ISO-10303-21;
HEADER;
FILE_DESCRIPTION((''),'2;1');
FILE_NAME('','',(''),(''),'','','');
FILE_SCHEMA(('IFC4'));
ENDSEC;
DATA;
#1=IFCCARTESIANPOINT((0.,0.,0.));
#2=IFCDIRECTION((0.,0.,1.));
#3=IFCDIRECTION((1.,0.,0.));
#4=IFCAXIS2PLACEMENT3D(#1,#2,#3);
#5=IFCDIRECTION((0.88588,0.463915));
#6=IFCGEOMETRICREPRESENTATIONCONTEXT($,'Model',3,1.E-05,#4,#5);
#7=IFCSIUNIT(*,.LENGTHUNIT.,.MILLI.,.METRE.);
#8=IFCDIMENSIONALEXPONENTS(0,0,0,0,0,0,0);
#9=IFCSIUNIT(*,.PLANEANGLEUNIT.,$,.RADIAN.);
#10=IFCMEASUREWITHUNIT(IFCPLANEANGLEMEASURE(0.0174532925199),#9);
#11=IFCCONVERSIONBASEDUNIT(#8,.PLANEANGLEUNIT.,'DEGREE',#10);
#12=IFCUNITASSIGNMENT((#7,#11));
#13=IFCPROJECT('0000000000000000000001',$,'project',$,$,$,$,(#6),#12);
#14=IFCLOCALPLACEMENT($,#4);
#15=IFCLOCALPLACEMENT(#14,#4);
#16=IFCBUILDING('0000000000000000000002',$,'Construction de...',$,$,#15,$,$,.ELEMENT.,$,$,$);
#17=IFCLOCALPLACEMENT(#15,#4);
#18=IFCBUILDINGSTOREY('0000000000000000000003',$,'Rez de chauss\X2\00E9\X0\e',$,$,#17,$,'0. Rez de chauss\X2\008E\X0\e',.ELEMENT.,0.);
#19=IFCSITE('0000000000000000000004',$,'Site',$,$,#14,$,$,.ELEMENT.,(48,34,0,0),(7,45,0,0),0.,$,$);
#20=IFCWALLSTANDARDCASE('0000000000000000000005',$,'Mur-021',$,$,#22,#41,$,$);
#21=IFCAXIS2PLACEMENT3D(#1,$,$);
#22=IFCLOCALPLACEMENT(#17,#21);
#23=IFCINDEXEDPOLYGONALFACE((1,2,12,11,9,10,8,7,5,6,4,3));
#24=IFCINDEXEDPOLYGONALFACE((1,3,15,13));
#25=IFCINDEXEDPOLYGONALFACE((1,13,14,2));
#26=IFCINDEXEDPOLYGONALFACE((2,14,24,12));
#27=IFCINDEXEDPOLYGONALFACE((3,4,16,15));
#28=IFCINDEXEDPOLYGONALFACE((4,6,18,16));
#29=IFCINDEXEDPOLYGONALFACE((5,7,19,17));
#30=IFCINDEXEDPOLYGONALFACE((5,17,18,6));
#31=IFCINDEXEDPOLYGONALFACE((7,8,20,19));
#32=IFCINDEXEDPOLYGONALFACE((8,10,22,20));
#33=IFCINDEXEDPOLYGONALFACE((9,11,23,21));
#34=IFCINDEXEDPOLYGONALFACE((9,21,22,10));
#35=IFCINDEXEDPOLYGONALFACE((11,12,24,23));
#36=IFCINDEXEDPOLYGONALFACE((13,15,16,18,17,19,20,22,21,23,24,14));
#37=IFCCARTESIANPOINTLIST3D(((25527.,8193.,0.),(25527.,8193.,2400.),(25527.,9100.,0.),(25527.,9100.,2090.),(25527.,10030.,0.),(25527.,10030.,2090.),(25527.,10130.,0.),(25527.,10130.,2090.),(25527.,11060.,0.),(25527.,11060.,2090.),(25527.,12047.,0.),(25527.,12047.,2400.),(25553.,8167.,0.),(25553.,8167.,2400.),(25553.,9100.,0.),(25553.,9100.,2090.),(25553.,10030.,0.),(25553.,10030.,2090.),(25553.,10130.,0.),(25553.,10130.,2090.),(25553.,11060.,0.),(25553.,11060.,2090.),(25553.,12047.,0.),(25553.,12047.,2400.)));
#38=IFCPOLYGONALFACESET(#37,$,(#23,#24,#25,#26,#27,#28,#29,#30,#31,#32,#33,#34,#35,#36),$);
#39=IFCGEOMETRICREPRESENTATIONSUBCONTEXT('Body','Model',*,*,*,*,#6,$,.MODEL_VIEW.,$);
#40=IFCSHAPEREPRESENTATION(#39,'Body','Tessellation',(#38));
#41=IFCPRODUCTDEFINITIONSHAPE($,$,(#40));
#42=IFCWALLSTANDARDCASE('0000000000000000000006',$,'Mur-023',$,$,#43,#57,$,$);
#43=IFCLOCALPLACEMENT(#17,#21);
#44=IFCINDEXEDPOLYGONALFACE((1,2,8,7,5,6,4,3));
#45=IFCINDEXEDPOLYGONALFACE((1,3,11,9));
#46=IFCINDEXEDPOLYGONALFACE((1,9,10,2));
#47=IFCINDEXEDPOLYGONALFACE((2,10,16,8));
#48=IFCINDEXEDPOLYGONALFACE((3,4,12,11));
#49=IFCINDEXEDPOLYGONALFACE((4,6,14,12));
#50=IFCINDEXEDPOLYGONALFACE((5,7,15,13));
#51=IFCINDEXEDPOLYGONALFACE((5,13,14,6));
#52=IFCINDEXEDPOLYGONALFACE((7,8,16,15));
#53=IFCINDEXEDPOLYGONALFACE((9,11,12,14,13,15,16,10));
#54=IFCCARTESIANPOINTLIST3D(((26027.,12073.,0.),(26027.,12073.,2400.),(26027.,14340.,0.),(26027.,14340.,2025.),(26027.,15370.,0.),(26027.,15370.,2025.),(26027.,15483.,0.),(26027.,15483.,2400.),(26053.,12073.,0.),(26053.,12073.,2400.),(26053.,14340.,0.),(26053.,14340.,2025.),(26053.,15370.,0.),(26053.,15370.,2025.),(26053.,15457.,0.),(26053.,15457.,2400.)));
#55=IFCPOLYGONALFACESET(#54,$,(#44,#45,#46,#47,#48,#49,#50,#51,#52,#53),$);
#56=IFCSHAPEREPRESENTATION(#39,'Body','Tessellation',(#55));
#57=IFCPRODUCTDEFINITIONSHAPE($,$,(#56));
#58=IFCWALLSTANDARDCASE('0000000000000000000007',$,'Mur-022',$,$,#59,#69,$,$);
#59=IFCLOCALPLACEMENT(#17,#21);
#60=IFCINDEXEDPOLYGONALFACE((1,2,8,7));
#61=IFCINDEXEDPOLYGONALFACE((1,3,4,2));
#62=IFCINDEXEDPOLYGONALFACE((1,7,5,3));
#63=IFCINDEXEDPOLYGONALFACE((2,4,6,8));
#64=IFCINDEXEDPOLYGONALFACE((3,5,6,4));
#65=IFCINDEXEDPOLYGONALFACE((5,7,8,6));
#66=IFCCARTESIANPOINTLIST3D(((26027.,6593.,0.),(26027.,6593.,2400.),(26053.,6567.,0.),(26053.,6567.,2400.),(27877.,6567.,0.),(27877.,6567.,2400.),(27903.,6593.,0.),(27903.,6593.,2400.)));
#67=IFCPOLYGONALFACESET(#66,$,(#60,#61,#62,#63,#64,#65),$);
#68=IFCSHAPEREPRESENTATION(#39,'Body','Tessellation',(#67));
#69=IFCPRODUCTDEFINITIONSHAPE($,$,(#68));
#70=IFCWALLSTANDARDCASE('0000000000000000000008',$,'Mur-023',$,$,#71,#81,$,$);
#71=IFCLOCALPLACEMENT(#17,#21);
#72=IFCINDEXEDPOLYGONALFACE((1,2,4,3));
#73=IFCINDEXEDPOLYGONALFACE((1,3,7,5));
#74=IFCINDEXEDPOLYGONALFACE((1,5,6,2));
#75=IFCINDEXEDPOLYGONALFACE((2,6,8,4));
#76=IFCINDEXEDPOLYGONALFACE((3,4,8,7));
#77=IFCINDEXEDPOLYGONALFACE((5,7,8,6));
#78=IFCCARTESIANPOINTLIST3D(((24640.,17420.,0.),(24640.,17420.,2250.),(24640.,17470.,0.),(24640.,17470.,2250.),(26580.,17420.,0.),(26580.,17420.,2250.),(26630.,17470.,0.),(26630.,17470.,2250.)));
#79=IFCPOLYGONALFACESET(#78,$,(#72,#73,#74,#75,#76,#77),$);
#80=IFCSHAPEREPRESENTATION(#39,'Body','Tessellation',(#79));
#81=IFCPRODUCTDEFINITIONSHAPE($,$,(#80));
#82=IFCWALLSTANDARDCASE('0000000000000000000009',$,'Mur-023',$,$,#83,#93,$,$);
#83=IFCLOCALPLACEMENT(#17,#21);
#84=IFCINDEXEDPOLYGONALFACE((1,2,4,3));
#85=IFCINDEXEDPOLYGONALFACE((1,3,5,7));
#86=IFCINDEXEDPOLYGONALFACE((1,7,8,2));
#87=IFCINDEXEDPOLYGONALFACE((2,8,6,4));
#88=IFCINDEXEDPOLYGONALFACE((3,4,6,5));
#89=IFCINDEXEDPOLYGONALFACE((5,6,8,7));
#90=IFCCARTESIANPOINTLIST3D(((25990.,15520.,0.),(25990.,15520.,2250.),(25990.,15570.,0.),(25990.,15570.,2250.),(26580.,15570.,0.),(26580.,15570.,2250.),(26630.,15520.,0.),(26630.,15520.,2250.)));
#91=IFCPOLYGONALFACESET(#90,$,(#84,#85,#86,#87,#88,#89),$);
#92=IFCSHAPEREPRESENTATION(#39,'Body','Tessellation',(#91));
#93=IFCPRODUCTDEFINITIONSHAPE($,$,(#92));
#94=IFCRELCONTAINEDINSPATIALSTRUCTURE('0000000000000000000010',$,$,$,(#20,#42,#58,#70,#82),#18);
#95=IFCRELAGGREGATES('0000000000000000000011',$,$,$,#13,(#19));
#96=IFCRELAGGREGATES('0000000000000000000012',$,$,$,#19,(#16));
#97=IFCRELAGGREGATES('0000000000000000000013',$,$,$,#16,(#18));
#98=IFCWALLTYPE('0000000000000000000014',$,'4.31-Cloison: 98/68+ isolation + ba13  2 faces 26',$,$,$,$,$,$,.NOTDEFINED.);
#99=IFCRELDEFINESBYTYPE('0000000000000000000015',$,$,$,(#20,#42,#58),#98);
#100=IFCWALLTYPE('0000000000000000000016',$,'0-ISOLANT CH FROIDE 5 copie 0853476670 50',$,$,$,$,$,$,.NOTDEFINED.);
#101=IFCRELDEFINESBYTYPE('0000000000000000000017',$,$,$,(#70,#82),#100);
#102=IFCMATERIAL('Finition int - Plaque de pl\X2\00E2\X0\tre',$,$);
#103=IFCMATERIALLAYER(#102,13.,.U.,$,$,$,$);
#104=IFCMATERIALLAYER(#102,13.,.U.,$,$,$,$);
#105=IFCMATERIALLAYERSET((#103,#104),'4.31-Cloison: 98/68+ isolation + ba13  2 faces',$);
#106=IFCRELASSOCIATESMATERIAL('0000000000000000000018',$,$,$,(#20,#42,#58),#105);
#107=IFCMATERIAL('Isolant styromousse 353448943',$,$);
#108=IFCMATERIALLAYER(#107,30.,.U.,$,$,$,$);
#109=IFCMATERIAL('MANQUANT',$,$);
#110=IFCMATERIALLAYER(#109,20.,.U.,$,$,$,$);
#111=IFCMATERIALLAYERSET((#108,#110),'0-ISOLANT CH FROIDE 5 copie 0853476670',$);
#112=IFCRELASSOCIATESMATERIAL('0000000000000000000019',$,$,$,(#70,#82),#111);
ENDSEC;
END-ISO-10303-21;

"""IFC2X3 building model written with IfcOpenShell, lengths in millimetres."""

from ifc_helpers import new_model, entity, si_unit, converted_unit, direction, frame, origin_with_axes, origin_2d_with_axis, place, context, subcontext, project, spatial, polyline, rectangle, outline, extrude, material, layer, layer_set, layer_usage, type_object, element, save


model = new_model("IFC2X3")

# Units and contexts
model_context = context("Model", 3, precision=1e-05, world=origin_with_axes(), true_north=direction((0.88588, 0.463915)))
body_context = subcontext(model_context, "Body", "Model", "MODEL_VIEW")
ifc_project = project(units=[si_unit("LENGTHUNIT", "METRE", prefix="MILLI"), converted_unit("PLANEANGLEUNIT", "DEGREE", entity("IfcPlaneAngleMeasure", 0.0174532925199), si_unit("PLANEANGLEUNIT", "RADIAN"), dimensions=[0, 0, 0, 0, 0, 0, 0])], contexts=[model_context])

# Site, building, storey
site_placement = place(None, origin_with_axes())
site = spatial("IfcSite", under=ifc_project, at=site_placement, Name="Site", CompositionType="ELEMENT", RefLatitude=(48, 34, 0, 0), RefLongitude=(7, 45, 0, 0), RefElevation=0.0)
building_placement = place(site_placement, origin_with_axes())
building = spatial("IfcBuilding", under=site, at=building_placement, Name="Construction de...", CompositionType="ELEMENT")
storey_placement = place(building_placement, origin_with_axes())
storey = spatial("IfcBuildingStorey", under=building, at=storey_placement, Name="Rez de chaussée", LongName="0. Rez de chauss\u008ee", CompositionType="ELEMENT", Elevation=0.0)

# Shared definitions
ifc_material_1 = material(Name="Isolant styromousse 353448943")

# Shared definitions
ifc_material_2 = material(Name="Finition int - Plaque de plâtre")
ifc_layer_1 = layer(ifc_material_2, 13.0, ventilated="UNKNOWN")
ifc_layer_2 = layer(ifc_material_2, 13.0, ventilated="UNKNOWN")
ifc_layer_set_1 = layer_set([ifc_layer_1, ifc_layer_2], Name="4.31-Cloison: 98/68+ isolation + ba13  2 faces")
wall_type_1 = type_object("IfcWallType", Name="4.31-Cloison: 98/68+ isolation + ba13  2 faces 26", PredefinedType="NOTDEFINED")

# Wall, openings
ifc_layer_usage_1 = layer_usage(ifc_layer_set_1, "AXIS2", "NEGATIVE", 13.0)
wall_1_placement = place(storey_placement, frame((25540.0, 8180.0, 0.0), z_axis=(0.0, 0.0, 1.0), x_axis=(0.0, 1.0, 0.0)))
wall_1 = element("IfcWallStandardCase", 1, at=wall_1_placement, inside=storey, type_object=wall_type_1, material=ifc_layer_usage_1, Name="Mur-021", context=body_context, shape_type="SweptSolid", body=[
    extrude(outline(polyline([(-13.0, -13.0), (3867.0, -13.0), (3867.0, 13.0), (13.0, 13.0), (-13.0, -13.0)])), origin_with_axes(), (0.0, 0.0, 1.0), 2400.0),
])
opening_1_placement = place(wall_1_placement, frame((2415.0, 0.0, 0.0), z_axis=(0.0, 0.0, 1.0), x_axis=(1.0, 0.0, 0.0)))
element("IfcOpeningElement", 2, at=opening_1_placement, cuts=wall_1, context=body_context, shape_type="SweptSolid", body=[
    extrude(rectangle(XDim=930.0, YDim=2090.0, at=origin_2d_with_axis()), frame((0.0, -26.0, 1045.0), z_axis=(0.0, -1.0, 0.0), x_axis=(-1.0, 0.0, 0.0)), (0.0, 0.0, -1.0), 78.0),
])
opening_2_placement = place(wall_1_placement, frame((1385.0, 0.0, 0.0), z_axis=(0.0, 0.0, 1.0), x_axis=(1.0, 0.0, 0.0)))
element("IfcOpeningElement", 3, at=opening_2_placement, cuts=wall_1, context=body_context, shape_type="SweptSolid", body=[
    extrude(rectangle(XDim=930.0, YDim=2090.0, at=origin_2d_with_axis()), frame((0.0, -26.0, 1045.0), z_axis=(0.0, 1.0, 0.0), x_axis=(1.0, 0.0, 0.0)), (0.0, 0.0, 1.0), 78.0),
])

# Wall, opening
ifc_layer_usage_2 = layer_usage(ifc_layer_set_1, "AXIS2", "NEGATIVE", 13.0)
wall_2_placement = place(storey_placement, frame((26040.0, 12060.0, 0.0), z_axis=(0.0, 0.0, 1.0), x_axis=(0.0, 1.0, 0.0)))
wall_2 = element("IfcWallStandardCase", 4, at=wall_2_placement, inside=storey, type_object=wall_type_1, material=ifc_layer_usage_2, Name="Mur-023", context=body_context, shape_type="SweptSolid", body=[
    extrude(outline(polyline([(13.0, -13.0), (3397.0, -13.0), (3423.0, 13.0), (13.0, 13.0), (13.0, -13.0)])), origin_with_axes(), (0.0, 0.0, 1.0), 2400.0),
])
opening_3_placement = place(wall_2_placement, frame((2795.0, 0.0, 0.0), z_axis=(0.0, 0.0, 1.0), x_axis=(1.0, 0.0, 0.0)))
element("IfcOpeningElement", 5, at=opening_3_placement, cuts=wall_2, context=body_context, shape_type="SweptSolid", body=[
    extrude(rectangle(XDim=1030.0, YDim=2025.0, at=origin_2d_with_axis()), frame((0.0, 26.0, 1012.5), z_axis=(0.0, 1.0, 0.0), x_axis=(1.0, 0.0, 0.0)), (0.0, 0.0, -1.0), 78.0),
])

# Walls
ifc_layer_usage_3 = layer_usage(ifc_layer_set_1, "AXIS2", "POSITIVE", -13.0)
wall_3_placement = place(storey_placement, frame((26040.0, 6580.0, 0.0), z_axis=(0.0, 0.0, 1.0), x_axis=(1.0, 0.0, 0.0)))
element("IfcWallStandardCase", 6, at=wall_3_placement, inside=storey, type_object=wall_type_1, material=ifc_layer_usage_3, Name="Mur-022", context=body_context, shape_type="SweptSolid", body=[
    extrude(outline(polyline([(13.0, -13.0), (1837.0, -13.0), (1863.0, 13.0), (-13.0, 13.0), (13.0, -13.0)])), origin_with_axes(), (0.0, 0.0, 1.0), 2400.0),
])
ifc_layer_3 = layer(ifc_material_1, 30.0, ventilated="UNKNOWN")
ifc_material_3 = material(Name="MANQUANT")
ifc_layer_4 = layer(ifc_material_3, 20.0, ventilated="UNKNOWN")
ifc_layer_set_2 = layer_set([ifc_layer_3, ifc_layer_4], Name="0-ISOLANT CH FROIDE 5 copie 0853476670")
ifc_layer_usage_4 = layer_usage(ifc_layer_set_2, "AXIS2", "NEGATIVE", 0.0)
wall_type_2 = type_object("IfcWallType", Name="0-ISOLANT CH FROIDE 5 copie 0853476670 50", PredefinedType="NOTDEFINED")
wall_4_placement = place(storey_placement, frame((24590.0, 17470.0, 0.0), z_axis=(0.0, 0.0, 1.0), x_axis=(1.0, 0.0, 0.0)))
element("IfcWallStandardCase", 7, at=wall_4_placement, inside=storey, type_object=wall_type_2, material=ifc_layer_usage_4, Name="Mur-023", context=body_context, shape_type="SweptSolid", body=[
    extrude(outline(polyline([(50.0, -50.0), (1990.0, -50.0), (2040.0, 0.0), (50.0, 0.0), (50.0, -50.0)])), origin_with_axes(), (0.0, 0.0, 1.0), 2250.0),
])
ifc_layer_usage_5 = layer_usage(ifc_layer_set_2, "AXIS2", "POSITIVE", 0.0)
wall_5_placement = place(storey_placement, frame((25990.0, 15520.0, 0.0), z_axis=(0.0, 0.0, 1.0), x_axis=(1.0, 0.0, 0.0)))
element("IfcWallStandardCase", 8, at=wall_5_placement, inside=storey, type_object=wall_type_2, material=ifc_layer_usage_5, Name="Mur-023", context=body_context, shape_type="SweptSolid", body=[
    extrude(outline(polyline([(0.0, 0.0), (640.0, 0.0), (590.0, 50.0), (0.0, 50.0), (0.0, 0.0)])), origin_with_axes(), (0.0, 0.0, 1.0), 2250.0),
])

save(model, "model.ifc")
